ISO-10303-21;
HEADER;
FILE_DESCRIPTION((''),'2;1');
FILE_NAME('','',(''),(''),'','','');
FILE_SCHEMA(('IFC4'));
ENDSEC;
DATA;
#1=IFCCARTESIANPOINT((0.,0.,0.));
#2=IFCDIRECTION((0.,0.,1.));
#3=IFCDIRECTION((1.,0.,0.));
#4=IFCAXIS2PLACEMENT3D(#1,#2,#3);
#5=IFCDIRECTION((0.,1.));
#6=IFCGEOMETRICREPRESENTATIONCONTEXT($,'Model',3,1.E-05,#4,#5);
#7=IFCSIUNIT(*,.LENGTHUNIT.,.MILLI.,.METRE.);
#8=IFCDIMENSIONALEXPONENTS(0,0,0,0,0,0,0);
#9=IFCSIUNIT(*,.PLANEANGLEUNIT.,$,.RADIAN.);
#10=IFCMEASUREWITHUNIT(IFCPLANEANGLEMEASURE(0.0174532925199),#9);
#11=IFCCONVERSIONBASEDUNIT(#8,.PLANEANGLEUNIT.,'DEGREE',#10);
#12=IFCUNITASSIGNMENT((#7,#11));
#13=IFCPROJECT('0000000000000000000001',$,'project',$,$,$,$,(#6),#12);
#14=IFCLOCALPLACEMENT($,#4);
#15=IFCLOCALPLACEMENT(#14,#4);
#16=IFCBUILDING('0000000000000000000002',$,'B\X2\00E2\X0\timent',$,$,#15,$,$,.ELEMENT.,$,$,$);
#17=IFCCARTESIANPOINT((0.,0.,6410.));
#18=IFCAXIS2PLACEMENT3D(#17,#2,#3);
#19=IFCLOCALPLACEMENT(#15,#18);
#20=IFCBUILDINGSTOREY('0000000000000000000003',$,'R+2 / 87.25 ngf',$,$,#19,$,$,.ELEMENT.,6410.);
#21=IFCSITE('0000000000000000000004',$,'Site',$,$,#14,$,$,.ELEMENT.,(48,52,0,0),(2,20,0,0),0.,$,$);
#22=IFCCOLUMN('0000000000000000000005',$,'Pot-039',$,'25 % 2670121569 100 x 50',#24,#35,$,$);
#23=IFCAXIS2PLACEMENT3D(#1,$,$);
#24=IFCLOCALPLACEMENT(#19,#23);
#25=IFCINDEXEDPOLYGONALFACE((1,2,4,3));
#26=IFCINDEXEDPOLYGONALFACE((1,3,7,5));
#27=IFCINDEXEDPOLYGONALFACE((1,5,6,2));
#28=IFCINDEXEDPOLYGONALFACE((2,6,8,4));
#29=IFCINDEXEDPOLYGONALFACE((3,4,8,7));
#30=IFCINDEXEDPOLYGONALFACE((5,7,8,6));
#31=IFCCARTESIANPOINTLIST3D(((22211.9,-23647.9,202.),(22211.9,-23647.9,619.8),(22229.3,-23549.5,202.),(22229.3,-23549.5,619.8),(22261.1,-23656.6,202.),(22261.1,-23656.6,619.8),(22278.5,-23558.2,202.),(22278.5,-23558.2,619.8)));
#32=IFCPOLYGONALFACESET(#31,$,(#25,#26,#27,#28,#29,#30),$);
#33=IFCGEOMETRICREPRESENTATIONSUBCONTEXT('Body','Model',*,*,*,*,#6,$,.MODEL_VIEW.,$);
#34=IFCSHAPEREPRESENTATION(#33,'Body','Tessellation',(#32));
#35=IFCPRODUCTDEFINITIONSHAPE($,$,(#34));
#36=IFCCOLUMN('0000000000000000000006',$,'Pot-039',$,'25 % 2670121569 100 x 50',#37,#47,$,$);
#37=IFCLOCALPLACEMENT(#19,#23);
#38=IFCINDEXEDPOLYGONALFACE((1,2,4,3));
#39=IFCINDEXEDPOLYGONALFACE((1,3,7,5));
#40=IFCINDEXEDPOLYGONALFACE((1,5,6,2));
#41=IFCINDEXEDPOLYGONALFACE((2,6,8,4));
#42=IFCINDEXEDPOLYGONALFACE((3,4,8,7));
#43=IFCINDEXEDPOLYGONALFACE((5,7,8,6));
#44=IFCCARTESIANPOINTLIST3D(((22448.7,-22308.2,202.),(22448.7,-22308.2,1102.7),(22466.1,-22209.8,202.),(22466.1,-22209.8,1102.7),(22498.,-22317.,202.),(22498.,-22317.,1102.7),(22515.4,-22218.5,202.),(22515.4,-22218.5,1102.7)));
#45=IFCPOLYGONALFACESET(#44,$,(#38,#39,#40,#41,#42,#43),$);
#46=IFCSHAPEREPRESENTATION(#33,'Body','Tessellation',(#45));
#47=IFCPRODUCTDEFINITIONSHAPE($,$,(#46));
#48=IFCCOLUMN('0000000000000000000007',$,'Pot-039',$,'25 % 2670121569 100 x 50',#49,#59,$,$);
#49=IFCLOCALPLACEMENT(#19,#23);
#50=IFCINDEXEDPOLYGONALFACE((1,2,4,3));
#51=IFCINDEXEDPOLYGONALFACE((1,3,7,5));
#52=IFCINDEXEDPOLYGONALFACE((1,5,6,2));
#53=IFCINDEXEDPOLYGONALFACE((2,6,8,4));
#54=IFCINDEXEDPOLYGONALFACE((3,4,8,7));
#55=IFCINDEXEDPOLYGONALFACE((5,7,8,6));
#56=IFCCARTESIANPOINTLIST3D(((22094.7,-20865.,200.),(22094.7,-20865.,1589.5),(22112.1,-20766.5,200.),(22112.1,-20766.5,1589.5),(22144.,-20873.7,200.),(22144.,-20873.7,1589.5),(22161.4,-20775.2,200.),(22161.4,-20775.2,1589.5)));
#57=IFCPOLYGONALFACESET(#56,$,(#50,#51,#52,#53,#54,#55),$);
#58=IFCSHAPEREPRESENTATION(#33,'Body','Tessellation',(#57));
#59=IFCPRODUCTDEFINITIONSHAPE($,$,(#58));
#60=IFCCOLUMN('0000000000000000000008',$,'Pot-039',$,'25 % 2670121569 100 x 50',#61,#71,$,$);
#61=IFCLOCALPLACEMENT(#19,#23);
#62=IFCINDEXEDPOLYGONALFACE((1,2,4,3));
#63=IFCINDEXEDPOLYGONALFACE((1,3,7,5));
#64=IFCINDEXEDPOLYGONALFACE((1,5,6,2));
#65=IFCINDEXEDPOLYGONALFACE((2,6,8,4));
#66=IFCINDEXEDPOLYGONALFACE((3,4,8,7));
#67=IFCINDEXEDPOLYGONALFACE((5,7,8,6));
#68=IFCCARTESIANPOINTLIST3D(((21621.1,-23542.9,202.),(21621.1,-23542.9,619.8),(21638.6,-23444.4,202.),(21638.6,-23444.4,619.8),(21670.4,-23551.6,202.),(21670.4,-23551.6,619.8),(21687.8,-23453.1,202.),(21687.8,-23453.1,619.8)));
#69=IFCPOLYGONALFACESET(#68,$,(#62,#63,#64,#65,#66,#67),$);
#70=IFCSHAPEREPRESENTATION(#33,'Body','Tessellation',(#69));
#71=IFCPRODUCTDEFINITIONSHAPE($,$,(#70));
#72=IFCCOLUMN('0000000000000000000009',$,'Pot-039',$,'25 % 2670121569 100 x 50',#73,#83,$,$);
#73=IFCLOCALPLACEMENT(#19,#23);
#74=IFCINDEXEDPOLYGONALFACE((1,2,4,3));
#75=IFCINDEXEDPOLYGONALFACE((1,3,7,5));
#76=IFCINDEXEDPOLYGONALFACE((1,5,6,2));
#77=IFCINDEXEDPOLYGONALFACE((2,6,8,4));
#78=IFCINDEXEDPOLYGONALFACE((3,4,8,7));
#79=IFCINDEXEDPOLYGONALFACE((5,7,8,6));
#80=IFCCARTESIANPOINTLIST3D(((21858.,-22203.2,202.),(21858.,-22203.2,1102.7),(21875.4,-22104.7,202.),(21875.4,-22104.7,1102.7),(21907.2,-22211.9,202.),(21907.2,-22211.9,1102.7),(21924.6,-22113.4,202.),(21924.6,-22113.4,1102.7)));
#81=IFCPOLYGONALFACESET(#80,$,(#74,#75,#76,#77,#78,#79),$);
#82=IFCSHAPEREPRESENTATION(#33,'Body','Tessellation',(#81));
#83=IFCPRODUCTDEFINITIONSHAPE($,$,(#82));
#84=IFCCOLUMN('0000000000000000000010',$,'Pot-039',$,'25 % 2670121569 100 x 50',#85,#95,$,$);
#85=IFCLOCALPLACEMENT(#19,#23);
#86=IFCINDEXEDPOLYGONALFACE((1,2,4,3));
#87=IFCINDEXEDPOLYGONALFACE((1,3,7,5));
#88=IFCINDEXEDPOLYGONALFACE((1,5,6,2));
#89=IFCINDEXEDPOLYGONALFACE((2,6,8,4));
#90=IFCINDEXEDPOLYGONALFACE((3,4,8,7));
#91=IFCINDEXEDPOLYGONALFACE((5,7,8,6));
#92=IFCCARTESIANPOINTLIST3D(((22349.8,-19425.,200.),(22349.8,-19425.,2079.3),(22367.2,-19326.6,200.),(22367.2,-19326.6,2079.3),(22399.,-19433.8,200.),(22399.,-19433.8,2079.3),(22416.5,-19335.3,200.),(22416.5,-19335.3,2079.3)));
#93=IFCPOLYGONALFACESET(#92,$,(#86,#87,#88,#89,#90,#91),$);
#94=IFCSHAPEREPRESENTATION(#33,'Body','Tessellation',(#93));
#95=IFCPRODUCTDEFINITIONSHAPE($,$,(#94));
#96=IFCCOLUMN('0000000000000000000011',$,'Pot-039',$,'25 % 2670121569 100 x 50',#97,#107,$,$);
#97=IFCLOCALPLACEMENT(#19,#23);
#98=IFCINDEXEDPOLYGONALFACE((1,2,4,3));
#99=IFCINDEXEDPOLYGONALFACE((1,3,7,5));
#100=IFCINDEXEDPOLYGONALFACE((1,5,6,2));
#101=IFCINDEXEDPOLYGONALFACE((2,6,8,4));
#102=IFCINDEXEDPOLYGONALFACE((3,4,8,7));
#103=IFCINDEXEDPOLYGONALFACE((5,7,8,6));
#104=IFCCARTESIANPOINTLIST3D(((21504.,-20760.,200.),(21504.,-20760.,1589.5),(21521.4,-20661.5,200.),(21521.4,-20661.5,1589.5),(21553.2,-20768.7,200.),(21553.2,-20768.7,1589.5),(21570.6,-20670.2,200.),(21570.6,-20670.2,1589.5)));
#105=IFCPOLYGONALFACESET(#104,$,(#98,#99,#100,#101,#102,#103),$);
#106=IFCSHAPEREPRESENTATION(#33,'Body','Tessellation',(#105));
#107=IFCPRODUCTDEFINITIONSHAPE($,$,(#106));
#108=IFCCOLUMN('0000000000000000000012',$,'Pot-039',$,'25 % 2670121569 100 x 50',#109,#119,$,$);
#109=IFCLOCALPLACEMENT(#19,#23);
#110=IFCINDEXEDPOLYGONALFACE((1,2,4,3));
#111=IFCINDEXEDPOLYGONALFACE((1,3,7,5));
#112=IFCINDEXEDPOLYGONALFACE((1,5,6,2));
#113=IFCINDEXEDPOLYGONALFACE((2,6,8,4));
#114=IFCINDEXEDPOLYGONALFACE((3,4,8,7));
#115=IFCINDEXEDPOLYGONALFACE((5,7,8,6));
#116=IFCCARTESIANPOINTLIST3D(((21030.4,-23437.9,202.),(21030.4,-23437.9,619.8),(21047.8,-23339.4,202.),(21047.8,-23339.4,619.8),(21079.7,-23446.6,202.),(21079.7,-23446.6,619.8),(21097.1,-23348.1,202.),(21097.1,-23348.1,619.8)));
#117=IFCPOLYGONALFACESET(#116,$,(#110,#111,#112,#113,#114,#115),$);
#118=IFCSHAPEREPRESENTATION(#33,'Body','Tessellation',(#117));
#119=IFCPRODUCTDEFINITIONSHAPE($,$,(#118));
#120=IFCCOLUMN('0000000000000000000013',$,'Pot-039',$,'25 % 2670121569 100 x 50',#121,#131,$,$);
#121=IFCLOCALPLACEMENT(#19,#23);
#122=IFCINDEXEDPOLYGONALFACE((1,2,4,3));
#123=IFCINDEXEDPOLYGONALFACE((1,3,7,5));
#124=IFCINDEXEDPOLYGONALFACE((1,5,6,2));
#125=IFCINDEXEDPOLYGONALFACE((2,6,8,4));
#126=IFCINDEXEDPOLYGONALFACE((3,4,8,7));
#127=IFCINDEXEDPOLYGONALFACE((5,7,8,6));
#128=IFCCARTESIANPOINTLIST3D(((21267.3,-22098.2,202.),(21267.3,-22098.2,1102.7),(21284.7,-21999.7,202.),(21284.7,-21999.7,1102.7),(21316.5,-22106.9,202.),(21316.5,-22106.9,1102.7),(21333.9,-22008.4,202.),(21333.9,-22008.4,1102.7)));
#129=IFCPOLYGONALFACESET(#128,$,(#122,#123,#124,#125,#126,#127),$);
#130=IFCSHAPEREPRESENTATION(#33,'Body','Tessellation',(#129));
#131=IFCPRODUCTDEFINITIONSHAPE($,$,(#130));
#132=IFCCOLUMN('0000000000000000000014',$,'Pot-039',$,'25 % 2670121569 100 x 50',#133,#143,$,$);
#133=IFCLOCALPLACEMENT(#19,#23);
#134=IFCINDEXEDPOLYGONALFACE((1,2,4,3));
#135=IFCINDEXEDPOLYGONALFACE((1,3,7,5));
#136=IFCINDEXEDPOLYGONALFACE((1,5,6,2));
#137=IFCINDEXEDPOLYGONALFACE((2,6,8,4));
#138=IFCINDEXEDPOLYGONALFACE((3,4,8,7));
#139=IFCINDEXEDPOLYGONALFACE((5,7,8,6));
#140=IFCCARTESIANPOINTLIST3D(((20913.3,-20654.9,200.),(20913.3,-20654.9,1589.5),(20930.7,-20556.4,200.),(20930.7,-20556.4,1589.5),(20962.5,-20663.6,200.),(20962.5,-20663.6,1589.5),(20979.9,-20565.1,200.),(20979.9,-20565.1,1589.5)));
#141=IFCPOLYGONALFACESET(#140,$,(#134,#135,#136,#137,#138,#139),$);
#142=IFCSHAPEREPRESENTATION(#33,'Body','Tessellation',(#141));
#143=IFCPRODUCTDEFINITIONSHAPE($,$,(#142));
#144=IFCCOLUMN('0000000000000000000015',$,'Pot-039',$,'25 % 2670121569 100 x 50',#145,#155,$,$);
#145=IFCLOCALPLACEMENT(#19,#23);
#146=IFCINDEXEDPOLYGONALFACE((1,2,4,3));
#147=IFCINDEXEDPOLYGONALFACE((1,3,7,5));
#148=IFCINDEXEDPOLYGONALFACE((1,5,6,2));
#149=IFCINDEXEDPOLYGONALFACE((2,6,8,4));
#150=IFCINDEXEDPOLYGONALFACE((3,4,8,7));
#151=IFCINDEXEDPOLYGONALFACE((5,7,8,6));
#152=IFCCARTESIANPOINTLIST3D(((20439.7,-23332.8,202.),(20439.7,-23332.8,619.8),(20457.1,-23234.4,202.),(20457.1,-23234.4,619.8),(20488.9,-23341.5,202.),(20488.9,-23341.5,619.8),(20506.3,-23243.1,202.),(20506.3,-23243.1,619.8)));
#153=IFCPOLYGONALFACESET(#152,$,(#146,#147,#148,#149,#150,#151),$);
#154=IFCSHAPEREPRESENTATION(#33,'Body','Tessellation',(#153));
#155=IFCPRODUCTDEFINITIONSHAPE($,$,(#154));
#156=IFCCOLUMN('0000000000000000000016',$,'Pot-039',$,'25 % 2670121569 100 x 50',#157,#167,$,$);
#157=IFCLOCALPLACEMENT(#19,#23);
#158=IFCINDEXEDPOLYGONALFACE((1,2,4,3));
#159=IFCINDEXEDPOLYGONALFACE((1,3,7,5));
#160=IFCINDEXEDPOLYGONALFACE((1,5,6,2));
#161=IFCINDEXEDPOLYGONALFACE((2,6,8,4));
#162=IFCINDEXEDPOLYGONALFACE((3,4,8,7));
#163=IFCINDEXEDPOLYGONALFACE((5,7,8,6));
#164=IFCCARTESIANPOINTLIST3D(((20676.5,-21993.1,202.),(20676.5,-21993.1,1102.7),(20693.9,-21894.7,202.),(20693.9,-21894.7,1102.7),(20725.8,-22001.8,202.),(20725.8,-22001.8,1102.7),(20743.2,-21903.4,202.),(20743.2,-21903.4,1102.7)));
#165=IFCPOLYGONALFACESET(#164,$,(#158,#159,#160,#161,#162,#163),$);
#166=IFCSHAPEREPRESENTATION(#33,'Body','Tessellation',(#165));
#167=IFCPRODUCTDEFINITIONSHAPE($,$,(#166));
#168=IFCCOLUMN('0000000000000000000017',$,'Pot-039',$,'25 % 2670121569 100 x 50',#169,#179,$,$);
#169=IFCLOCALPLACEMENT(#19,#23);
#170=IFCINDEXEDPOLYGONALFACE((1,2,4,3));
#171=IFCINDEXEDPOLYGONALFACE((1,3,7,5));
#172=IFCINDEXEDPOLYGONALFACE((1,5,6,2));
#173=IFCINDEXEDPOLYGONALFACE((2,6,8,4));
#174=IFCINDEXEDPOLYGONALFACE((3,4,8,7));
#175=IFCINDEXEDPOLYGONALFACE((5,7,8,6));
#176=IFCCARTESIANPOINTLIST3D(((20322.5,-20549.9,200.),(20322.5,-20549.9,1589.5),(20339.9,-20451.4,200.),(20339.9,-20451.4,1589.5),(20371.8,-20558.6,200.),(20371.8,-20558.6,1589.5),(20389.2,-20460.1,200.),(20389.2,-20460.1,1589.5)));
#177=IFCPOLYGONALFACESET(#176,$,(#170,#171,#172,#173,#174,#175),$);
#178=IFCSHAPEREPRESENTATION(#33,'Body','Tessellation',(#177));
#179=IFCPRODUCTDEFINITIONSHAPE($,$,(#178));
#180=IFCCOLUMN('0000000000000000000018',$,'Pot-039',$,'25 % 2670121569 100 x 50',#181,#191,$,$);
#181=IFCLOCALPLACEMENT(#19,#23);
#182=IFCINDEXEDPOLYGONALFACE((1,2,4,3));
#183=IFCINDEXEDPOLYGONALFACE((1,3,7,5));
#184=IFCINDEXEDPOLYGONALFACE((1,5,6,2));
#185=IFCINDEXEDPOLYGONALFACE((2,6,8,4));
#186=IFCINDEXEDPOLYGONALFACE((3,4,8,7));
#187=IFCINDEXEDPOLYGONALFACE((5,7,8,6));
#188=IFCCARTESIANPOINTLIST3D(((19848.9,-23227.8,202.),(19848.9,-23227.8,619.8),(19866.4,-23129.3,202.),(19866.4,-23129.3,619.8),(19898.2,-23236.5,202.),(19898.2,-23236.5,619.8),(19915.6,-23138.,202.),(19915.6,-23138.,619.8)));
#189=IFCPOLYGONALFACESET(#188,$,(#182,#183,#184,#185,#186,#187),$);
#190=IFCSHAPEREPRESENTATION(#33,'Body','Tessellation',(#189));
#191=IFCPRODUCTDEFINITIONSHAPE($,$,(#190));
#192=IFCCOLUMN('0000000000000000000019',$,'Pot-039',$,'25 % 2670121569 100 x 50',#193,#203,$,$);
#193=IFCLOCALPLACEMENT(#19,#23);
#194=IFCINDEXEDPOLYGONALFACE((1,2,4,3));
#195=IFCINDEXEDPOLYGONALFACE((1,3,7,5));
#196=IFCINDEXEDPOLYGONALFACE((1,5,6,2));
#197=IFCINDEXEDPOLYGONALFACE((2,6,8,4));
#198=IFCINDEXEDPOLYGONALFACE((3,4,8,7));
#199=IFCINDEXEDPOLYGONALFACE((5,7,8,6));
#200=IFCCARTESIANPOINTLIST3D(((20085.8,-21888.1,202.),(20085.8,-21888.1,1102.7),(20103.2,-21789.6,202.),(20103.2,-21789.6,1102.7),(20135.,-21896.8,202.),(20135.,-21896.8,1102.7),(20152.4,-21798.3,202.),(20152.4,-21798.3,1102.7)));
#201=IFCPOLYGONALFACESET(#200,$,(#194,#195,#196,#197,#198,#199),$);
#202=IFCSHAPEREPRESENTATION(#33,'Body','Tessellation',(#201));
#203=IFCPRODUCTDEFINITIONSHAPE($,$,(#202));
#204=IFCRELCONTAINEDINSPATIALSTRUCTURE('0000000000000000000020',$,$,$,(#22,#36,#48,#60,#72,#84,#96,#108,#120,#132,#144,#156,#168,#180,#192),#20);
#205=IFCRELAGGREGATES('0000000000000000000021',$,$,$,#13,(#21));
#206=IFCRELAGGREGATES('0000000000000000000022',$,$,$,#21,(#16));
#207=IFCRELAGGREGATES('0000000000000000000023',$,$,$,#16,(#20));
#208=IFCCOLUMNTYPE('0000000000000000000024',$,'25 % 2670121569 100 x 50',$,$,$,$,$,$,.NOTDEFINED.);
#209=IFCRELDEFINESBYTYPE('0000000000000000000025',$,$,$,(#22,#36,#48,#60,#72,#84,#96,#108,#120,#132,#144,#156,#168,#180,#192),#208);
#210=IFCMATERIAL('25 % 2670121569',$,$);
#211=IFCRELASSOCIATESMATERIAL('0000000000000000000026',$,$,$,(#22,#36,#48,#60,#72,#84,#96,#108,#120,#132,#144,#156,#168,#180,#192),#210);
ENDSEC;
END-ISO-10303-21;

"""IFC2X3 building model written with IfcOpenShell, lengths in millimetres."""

from ifc_helpers import new_model, entity, si_unit, converted_unit, direction, frame, origin_with_axes, origin_2d_with_axis, place, context, subcontext, project, spatial, rectangle, extrude, material, type_object, element, save


model = new_model("IFC2X3")

# Units and contexts
model_context = context("Model", 3, precision=1e-05, world=origin_with_axes(), true_north=direction((0.0, 1.0)))
body_context = subcontext(model_context, "Body", "Model", "MODEL_VIEW")
ifc_project = project(units=[si_unit("LENGTHUNIT", "METRE", prefix="MILLI"), converted_unit("PLANEANGLEUNIT", "DEGREE", entity("IfcPlaneAngleMeasure", 0.0174532925199), si_unit("PLANEANGLEUNIT", "RADIAN"), dimensions=[0, 0, 0, 0, 0, 0, 0])], contexts=[model_context])

# Site, building, storey
site_placement = place(None, origin_with_axes())
site = spatial("IfcSite", under=ifc_project, at=site_placement, Name="Site", CompositionType="ELEMENT", RefLatitude=(48, 52, 0, 0), RefLongitude=(2, 20, 0, 0), RefElevation=0.0)
building_placement = place(site_placement, origin_with_axes())
building = spatial("IfcBuilding", under=site, at=building_placement, Name="Bâtiment", CompositionType="ELEMENT")
storey_placement = place(building_placement, frame((0.0, 0.0, 6410.0), z_axis=(0.0, 0.0, 1.0), x_axis=(1.0, 0.0, 0.0)))
storey = spatial("IfcBuildingStorey", under=building, at=storey_placement, Name="R+2 / 87.25 ngf", CompositionType="ELEMENT", Elevation=6410.0)

# Columns
ifc_material_1 = material(Name="25 % 2670121569")
column_type = type_object("IfcColumnType", Name="25 % 2670121569 100 x 50", PredefinedType="NOTDEFINED")
column_1_placement = place(storey_placement, frame((22245.2, -23603.1, 202.0), z_axis=(0.0, 0.0, 1.0), x_axis=(0.17408, 0.984731, 0.0)))
element("IfcColumn", 1, at=column_1_placement, inside=storey, type_object=column_type, material=ifc_material_1, Name="Pot-039", ObjectType="25 % 2670121569 100 x 50", context=body_context, shape_type="SweptSolid", body=[
    extrude(rectangle(XDim=100.0, YDim=50.0, at=origin_2d_with_axis()), origin_with_axes(), (0.0, 0.0, 1.0), 417.8),
])
column_2_placement = place(storey_placement, frame((22482.1, -22263.4, 202.0), z_axis=(0.0, 0.0, 1.0), x_axis=(0.17408, 0.984731, 0.0)))
element("IfcColumn", 2, at=column_2_placement, inside=storey, type_object=column_type, material=ifc_material_1, Name="Pot-039", ObjectType="25 % 2670121569 100 x 50", context=body_context, shape_type="SweptSolid", body=[
    extrude(rectangle(XDim=100.0, YDim=50.0, at=origin_2d_with_axis()), origin_with_axes(), (0.0, 0.0, 1.0), 900.7),
])
column_3_placement = place(storey_placement, frame((22128.0, -20820.1, 200.0), z_axis=(0.0, 0.0, 1.0), x_axis=(0.17408, 0.984731, 0.0)))
element("IfcColumn", 3, at=column_3_placement, inside=storey, type_object=column_type, material=ifc_material_1, Name="Pot-039", ObjectType="25 % 2670121569 100 x 50", context=body_context, shape_type="SweptSolid", body=[
    extrude(rectangle(XDim=100.0, YDim=50.0, at=origin_2d_with_axis()), origin_with_axes(), (0.0, 0.0, 1.0), 1389.5),
])
column_4_placement = place(storey_placement, frame((21654.5, -23498.0, 202.0), z_axis=(0.0, 0.0, 1.0), x_axis=(0.17408, 0.984731, 0.0)))
element("IfcColumn", 4, at=column_4_placement, inside=storey, type_object=column_type, material=ifc_material_1, Name="Pot-039", ObjectType="25 % 2670121569 100 x 50", context=body_context, shape_type="SweptSolid", body=[
    extrude(rectangle(XDim=100.0, YDim=50.0, at=origin_2d_with_axis()), origin_with_axes(), (0.0, 0.0, 1.0), 417.8),
])
column_5_placement = place(storey_placement, frame((21891.3, -22158.3, 202.0), z_axis=(0.0, 0.0, 1.0), x_axis=(0.17408, 0.984731, 0.0)))
element("IfcColumn", 5, at=column_5_placement, inside=storey, type_object=column_type, material=ifc_material_1, Name="Pot-039", ObjectType="25 % 2670121569 100 x 50", context=body_context, shape_type="SweptSolid", body=[
    extrude(rectangle(XDim=100.0, YDim=50.0, at=origin_2d_with_axis()), origin_with_axes(), (0.0, 0.0, 1.0), 900.7),
])
column_6_placement = place(storey_placement, frame((22383.1, -19380.2, 200.0), z_axis=(0.0, 0.0, 1.0), x_axis=(0.17478, 0.984607, 0.0)))
element("IfcColumn", 6, at=column_6_placement, inside=storey, type_object=column_type, material=ifc_material_1, Name="Pot-039", ObjectType="25 % 2670121569 100 x 50", context=body_context, shape_type="SweptSolid", body=[
    extrude(rectangle(XDim=100.0, YDim=50.0, at=origin_2d_with_axis()), origin_with_axes(), (0.0, 0.0, 1.0), 1879.3),
])
column_7_placement = place(storey_placement, frame((21537.3, -20715.1, 200.0), z_axis=(0.0, 0.0, 1.0), x_axis=(0.17408, 0.984731, 0.0)))
element("IfcColumn", 7, at=column_7_placement, inside=storey, type_object=column_type, material=ifc_material_1, Name="Pot-039", ObjectType="25 % 2670121569 100 x 50", context=body_context, shape_type="SweptSolid", body=[
    extrude(rectangle(XDim=100.0, YDim=50.0, at=origin_2d_with_axis()), origin_with_axes(), (0.0, 0.0, 1.0), 1389.5),
])
column_8_placement = place(storey_placement, frame((21063.7, -23393.0, 202.0), z_axis=(0.0, 0.0, 1.0), x_axis=(0.17408, 0.984731, 0.0)))
element("IfcColumn", 8, at=column_8_placement, inside=storey, type_object=column_type, material=ifc_material_1, Name="Pot-039", ObjectType="25 % 2670121569 100 x 50", context=body_context, shape_type="SweptSolid", body=[
    extrude(rectangle(XDim=100.0, YDim=50.0, at=origin_2d_with_axis()), origin_with_axes(), (0.0, 0.0, 1.0), 417.8),
])
column_9_placement = place(storey_placement, frame((21300.6, -22053.3, 202.0), z_axis=(0.0, 0.0, 1.0), x_axis=(0.17408, 0.984731, 0.0)))
element("IfcColumn", 9, at=column_9_placement, inside=storey, type_object=column_type, material=ifc_material_1, Name="Pot-039", ObjectType="25 % 2670121569 100 x 50", context=body_context, shape_type="SweptSolid", body=[
    extrude(rectangle(XDim=100.0, YDim=50.0, at=origin_2d_with_axis()), origin_with_axes(), (0.0, 0.0, 1.0), 900.7),
])
column_10_placement = place(storey_placement, frame((20946.6, -20610.0, 200.0), z_axis=(0.0, 0.0, 1.0), x_axis=(0.17408, 0.984731, 0.0)))
element("IfcColumn", 10, at=column_10_placement, inside=storey, type_object=column_type, material=ifc_material_1, Name="Pot-039", ObjectType="25 % 2670121569 100 x 50", context=body_context, shape_type="SweptSolid", body=[
    extrude(rectangle(XDim=100.0, YDim=50.0, at=origin_2d_with_axis()), origin_with_axes(), (0.0, 0.0, 1.0), 1389.5),
])
column_11_placement = place(storey_placement, frame((20473.0, -23287.9, 202.0), z_axis=(0.0, 0.0, 1.0), x_axis=(0.17408, 0.984731, 0.0)))
element("IfcColumn", 11, at=column_11_placement, inside=storey, type_object=column_type, material=ifc_material_1, Name="Pot-039", ObjectType="25 % 2670121569 100 x 50", context=body_context, shape_type="SweptSolid", body=[
    extrude(rectangle(XDim=100.0, YDim=50.0, at=origin_2d_with_axis()), origin_with_axes(), (0.0, 0.0, 1.0), 417.8),
])
column_12_placement = place(storey_placement, frame((20709.9, -21948.3, 202.0), z_axis=(0.0, 0.0, 1.0), x_axis=(0.17408, 0.984731, 0.0)))
element("IfcColumn", 12, at=column_12_placement, inside=storey, type_object=column_type, material=ifc_material_1, Name="Pot-039", ObjectType="25 % 2670121569 100 x 50", context=body_context, shape_type="SweptSolid", body=[
    extrude(rectangle(XDim=100.0, YDim=50.0, at=origin_2d_with_axis()), origin_with_axes(), (0.0, 0.0, 1.0), 900.7),
])
column_13_placement = place(storey_placement, frame((20355.8, -20505.0, 200.0), z_axis=(0.0, 0.0, 1.0), x_axis=(0.17408, 0.984731, 0.0)))
element("IfcColumn", 13, at=column_13_placement, inside=storey, type_object=column_type, material=ifc_material_1, Name="Pot-039", ObjectType="25 % 2670121569 100 x 50", context=body_context, shape_type="SweptSolid", body=[
    extrude(rectangle(XDim=100.0, YDim=50.0, at=origin_2d_with_axis()), origin_with_axes(), (0.0, 0.0, 1.0), 1389.5),
])
column_14_placement = place(storey_placement, frame((19882.3, -23182.9, 202.0), z_axis=(0.0, 0.0, 1.0), x_axis=(0.17408, 0.984731, 0.0)))
element("IfcColumn", 14, at=column_14_placement, inside=storey, type_object=column_type, material=ifc_material_1, Name="Pot-039", ObjectType="25 % 2670121569 100 x 50", context=body_context, shape_type="SweptSolid", body=[
    extrude(rectangle(XDim=100.0, YDim=50.0, at=origin_2d_with_axis()), origin_with_axes(), (0.0, 0.0, 1.0), 417.8),
])
column_15_placement = place(storey_placement, frame((20119.1, -21843.2, 202.0), z_axis=(0.0, 0.0, 1.0), x_axis=(0.17408, 0.984731, 0.0)))
element("IfcColumn", 15, at=column_15_placement, inside=storey, type_object=column_type, material=ifc_material_1, Name="Pot-039", ObjectType="25 % 2670121569 100 x 50", context=body_context, shape_type="SweptSolid", body=[
    extrude(rectangle(XDim=100.0, YDim=50.0, at=origin_2d_with_axis()), origin_with_axes(), (0.0, 0.0, 1.0), 900.7),
])

save(model, "model.ifc")
